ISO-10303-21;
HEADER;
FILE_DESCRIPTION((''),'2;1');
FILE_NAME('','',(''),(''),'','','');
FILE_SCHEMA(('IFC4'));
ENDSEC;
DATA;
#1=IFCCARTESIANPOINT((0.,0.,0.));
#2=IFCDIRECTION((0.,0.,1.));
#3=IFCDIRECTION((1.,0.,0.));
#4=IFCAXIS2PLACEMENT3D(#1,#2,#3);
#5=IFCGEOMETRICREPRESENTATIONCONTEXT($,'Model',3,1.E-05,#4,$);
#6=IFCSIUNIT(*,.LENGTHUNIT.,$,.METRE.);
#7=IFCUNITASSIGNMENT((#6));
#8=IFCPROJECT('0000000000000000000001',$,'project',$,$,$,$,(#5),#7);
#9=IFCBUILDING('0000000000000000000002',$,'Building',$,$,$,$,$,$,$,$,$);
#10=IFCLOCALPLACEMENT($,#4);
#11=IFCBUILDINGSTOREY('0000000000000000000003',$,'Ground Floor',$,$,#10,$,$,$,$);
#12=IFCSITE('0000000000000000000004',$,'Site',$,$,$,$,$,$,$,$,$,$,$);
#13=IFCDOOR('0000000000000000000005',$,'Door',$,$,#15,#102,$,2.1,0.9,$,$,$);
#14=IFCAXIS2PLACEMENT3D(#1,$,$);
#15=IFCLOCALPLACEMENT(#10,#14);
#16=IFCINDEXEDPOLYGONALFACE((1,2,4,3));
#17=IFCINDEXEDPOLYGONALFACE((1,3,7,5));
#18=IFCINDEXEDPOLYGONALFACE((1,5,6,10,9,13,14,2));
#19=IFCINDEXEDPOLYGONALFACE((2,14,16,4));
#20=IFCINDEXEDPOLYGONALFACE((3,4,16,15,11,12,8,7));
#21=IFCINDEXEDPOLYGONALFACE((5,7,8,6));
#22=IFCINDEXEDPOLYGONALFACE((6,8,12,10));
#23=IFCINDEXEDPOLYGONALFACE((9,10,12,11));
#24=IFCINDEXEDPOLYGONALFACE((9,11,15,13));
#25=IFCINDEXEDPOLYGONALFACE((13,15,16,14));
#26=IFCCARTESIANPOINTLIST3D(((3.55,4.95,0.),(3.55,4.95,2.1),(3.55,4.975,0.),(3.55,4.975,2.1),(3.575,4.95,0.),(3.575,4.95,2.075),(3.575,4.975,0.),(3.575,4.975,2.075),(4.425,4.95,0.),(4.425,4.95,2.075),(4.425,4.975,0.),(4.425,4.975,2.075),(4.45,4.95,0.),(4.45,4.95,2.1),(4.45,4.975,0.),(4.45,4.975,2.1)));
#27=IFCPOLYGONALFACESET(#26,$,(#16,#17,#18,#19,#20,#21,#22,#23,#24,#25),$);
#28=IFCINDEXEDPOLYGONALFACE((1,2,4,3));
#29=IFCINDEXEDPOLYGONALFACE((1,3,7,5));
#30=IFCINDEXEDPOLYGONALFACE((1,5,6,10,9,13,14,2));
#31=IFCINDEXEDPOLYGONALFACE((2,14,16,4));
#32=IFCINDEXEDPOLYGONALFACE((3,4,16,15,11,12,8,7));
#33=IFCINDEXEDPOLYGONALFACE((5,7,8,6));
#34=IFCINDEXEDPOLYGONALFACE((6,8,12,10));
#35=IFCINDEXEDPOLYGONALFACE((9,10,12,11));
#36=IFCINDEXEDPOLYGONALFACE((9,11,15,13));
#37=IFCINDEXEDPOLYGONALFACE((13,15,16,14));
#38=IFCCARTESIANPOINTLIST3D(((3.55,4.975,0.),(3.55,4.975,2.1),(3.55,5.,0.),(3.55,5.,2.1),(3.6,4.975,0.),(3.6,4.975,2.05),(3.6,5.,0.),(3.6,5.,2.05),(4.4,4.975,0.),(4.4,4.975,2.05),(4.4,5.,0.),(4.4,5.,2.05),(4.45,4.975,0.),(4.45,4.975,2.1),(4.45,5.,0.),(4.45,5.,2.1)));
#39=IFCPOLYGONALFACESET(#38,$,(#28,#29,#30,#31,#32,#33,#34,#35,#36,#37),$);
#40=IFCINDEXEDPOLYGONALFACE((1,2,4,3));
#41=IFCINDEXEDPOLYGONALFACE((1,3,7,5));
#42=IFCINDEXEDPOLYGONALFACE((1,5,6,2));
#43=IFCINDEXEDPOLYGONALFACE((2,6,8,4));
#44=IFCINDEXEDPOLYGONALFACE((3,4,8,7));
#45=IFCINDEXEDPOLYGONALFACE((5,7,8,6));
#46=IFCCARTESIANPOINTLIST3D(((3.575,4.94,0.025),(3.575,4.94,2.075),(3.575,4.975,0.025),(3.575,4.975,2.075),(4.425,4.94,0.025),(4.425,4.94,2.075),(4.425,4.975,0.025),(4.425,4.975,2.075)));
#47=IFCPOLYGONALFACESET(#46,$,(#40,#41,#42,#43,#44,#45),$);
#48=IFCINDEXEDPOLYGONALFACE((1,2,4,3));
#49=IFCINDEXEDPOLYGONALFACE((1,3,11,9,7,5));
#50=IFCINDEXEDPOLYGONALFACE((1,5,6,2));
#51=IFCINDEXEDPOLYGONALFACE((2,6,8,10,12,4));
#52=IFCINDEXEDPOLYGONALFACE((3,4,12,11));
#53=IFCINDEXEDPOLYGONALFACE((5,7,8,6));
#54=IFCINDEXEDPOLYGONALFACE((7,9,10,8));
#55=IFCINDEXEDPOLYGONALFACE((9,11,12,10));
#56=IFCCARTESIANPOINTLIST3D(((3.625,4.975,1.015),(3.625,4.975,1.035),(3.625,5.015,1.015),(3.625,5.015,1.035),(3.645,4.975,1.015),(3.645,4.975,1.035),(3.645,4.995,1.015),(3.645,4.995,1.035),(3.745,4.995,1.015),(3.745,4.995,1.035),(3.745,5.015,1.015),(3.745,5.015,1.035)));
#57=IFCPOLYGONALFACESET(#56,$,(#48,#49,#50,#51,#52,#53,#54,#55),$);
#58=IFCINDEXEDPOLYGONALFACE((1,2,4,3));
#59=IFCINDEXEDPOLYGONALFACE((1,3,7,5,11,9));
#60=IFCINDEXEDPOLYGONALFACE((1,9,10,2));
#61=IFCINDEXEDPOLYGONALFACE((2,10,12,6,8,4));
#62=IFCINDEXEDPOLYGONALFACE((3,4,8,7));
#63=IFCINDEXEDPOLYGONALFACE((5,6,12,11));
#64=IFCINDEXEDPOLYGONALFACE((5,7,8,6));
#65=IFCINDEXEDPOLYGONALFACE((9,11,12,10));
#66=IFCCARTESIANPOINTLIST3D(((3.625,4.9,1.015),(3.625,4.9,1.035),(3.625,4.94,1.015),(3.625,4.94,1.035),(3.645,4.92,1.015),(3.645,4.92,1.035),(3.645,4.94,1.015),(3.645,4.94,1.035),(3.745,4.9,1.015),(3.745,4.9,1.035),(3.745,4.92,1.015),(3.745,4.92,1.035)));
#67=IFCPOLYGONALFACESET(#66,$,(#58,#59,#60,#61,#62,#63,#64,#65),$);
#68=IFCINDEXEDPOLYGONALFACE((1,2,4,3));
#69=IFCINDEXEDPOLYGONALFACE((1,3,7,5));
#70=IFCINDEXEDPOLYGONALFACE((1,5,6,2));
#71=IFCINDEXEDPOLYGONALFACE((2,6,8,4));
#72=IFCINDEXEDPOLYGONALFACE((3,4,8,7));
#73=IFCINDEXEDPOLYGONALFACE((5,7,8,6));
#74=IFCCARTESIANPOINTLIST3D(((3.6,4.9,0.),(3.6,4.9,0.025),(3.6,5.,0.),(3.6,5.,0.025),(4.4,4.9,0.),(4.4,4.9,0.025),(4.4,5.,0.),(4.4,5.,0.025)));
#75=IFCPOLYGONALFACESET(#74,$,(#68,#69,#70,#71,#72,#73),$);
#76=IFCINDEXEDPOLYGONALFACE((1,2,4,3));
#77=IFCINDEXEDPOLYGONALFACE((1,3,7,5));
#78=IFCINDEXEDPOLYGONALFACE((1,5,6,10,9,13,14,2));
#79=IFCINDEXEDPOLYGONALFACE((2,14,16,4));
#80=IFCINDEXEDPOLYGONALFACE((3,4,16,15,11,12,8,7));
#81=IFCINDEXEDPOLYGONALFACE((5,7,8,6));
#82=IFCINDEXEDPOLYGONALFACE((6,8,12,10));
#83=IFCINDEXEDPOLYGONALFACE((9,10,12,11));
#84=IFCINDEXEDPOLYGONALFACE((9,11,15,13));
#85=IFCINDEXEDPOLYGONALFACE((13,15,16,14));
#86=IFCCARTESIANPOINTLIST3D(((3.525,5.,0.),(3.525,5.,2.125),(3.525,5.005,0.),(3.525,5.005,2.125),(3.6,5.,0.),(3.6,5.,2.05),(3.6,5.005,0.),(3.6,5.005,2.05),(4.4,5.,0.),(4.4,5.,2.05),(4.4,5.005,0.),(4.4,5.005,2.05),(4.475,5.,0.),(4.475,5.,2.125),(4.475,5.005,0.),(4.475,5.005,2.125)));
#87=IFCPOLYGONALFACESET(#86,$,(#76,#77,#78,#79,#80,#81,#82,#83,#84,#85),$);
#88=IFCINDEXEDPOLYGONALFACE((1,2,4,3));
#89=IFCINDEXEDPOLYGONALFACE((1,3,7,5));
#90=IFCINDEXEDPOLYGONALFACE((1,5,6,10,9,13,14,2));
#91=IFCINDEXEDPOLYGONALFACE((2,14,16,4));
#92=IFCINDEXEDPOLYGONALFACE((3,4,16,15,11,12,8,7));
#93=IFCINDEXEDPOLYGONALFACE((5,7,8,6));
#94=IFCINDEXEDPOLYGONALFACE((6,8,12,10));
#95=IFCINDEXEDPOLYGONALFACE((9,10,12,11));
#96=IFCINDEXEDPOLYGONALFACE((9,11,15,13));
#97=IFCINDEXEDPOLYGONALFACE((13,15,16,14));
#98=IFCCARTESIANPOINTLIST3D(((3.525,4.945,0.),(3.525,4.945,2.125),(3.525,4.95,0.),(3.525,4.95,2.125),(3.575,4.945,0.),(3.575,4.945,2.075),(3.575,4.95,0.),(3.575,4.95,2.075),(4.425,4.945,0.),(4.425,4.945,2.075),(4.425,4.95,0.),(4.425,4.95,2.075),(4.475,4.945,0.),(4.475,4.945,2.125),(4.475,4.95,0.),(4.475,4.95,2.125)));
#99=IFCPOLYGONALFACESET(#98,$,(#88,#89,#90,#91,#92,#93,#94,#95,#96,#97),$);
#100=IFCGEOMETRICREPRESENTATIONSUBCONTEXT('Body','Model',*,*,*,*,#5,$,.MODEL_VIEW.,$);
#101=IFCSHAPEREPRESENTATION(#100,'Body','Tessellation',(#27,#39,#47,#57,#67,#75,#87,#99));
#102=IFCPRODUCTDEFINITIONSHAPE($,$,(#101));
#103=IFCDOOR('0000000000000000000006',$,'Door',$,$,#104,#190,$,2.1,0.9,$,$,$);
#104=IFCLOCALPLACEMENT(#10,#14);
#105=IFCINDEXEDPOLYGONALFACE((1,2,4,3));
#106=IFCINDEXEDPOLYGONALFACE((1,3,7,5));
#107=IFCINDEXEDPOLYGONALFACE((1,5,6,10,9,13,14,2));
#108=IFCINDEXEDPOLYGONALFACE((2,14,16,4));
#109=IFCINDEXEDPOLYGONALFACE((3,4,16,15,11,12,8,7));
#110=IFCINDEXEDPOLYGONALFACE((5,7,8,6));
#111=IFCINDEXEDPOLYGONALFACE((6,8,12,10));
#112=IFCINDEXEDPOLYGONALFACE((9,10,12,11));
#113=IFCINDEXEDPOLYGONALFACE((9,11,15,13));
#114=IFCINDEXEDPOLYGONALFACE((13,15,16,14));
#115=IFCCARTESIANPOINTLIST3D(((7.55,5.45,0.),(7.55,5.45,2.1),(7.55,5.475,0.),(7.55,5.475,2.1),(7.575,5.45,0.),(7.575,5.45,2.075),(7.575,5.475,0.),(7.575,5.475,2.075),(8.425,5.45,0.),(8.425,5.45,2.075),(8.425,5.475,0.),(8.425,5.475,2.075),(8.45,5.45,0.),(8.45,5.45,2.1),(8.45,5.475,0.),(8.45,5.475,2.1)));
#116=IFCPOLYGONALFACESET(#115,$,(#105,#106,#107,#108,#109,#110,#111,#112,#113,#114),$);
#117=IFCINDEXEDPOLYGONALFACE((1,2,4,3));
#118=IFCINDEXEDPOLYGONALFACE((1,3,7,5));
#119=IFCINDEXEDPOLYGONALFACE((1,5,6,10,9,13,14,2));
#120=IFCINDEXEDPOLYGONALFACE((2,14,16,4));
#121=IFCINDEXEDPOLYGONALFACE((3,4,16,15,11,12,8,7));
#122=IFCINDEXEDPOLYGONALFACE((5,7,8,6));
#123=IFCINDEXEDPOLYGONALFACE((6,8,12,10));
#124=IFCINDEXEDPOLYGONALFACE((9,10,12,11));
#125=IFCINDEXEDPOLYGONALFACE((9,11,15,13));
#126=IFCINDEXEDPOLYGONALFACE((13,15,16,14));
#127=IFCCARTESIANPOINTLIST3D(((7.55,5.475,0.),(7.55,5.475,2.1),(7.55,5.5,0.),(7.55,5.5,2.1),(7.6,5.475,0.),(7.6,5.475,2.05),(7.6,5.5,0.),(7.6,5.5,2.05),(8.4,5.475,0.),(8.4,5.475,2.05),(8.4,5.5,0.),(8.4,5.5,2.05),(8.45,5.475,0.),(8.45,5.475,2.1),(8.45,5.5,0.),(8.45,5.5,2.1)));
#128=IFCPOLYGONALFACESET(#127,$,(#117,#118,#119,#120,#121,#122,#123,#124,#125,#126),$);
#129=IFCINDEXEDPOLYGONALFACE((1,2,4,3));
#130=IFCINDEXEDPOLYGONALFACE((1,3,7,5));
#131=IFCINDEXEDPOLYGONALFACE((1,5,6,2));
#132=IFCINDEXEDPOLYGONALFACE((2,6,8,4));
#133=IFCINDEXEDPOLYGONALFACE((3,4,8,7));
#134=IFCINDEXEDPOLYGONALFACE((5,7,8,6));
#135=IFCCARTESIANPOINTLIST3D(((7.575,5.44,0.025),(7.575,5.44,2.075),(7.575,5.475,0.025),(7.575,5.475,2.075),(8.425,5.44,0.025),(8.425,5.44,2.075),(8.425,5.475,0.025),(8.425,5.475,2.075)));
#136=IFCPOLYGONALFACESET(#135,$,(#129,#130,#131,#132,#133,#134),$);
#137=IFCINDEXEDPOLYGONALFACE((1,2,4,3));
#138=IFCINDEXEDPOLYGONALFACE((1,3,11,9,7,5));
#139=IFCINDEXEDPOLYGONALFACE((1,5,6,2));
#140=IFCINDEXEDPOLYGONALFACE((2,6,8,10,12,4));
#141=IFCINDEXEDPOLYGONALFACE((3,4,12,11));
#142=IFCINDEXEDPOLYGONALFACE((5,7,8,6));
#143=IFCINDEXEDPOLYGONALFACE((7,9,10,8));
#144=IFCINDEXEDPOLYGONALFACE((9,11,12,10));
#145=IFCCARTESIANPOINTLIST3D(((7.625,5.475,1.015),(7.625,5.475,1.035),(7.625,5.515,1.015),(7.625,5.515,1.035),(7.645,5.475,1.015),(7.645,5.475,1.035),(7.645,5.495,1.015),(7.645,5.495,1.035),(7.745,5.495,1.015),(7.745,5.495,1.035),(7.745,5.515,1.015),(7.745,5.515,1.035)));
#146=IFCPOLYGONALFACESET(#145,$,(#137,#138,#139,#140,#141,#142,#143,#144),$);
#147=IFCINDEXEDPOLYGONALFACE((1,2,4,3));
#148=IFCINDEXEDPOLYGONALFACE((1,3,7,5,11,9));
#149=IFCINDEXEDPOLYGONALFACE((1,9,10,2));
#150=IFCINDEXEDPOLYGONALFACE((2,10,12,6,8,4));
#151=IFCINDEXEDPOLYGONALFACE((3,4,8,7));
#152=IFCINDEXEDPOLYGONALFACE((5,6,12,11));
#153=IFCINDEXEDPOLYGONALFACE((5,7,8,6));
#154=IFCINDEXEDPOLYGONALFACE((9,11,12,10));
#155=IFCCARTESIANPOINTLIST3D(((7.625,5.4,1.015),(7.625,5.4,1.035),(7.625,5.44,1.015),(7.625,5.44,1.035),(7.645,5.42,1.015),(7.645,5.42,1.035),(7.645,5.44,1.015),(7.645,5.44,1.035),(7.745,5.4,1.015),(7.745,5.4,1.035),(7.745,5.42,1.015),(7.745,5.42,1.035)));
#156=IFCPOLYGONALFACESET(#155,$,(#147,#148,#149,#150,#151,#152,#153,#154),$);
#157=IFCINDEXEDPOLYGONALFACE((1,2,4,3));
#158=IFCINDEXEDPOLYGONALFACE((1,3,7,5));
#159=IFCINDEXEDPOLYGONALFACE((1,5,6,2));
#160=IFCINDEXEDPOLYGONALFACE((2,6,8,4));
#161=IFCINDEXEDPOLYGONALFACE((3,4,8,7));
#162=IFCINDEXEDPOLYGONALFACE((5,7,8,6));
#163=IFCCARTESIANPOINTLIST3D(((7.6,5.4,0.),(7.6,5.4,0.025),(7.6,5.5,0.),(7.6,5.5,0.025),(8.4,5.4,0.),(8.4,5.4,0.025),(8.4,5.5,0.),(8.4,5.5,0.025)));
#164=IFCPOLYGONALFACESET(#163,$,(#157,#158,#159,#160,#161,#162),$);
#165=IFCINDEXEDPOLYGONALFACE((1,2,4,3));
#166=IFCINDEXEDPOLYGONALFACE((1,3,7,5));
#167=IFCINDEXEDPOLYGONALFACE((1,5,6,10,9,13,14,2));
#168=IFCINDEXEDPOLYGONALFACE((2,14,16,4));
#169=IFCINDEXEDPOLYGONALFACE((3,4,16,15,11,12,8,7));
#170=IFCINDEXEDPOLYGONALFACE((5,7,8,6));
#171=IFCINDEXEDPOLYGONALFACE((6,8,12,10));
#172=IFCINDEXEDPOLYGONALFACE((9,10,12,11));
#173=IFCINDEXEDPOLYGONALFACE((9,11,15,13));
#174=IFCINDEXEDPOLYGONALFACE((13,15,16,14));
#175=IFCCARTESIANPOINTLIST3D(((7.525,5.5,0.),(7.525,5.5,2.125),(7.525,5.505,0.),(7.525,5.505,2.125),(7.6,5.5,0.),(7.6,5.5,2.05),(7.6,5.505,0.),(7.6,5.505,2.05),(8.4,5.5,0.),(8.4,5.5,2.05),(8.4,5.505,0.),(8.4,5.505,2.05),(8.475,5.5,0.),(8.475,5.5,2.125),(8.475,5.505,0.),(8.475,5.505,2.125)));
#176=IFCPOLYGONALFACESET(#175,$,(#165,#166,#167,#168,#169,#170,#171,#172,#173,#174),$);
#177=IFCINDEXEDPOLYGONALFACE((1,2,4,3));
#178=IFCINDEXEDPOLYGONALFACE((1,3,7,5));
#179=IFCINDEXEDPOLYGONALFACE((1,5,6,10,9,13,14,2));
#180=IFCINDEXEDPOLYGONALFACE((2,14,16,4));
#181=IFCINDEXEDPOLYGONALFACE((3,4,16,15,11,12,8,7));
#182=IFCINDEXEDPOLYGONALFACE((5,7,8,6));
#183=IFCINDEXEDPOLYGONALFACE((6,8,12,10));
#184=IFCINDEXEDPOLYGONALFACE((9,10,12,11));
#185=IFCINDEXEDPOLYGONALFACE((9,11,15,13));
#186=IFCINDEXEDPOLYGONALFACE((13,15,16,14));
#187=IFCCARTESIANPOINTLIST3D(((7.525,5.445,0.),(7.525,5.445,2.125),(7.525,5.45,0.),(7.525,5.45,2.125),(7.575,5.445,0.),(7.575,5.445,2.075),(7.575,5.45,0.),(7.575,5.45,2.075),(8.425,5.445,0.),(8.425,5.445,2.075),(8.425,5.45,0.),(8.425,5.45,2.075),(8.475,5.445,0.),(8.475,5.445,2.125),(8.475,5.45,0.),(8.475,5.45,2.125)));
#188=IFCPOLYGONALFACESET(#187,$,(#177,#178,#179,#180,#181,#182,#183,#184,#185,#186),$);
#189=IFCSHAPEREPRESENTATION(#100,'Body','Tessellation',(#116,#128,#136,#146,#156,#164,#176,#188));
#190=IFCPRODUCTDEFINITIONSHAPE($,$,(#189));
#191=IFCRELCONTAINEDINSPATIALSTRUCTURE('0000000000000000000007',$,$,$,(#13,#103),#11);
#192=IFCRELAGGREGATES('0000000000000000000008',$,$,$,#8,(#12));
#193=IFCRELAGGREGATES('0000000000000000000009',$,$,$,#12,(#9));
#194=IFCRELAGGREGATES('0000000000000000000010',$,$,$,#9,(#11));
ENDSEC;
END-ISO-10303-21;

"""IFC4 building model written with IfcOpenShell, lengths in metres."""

from ifc_helpers import new_model, si_unit, frame, origin_with_axes, place, context, subcontext, project, spatial, line, indexed_curve, outline, extrude, element, save


model = new_model("IFC4")

# Units and contexts
model_context = context("Model", 3, precision=1e-05, world=origin_with_axes())
body_context = subcontext(model_context, "Body", "Model", "MODEL_VIEW")
ifc_project = project(units=[si_unit("LENGTHUNIT", "METRE")], contexts=[model_context])

# Site, building, storey
site = spatial("IfcSite", under=ifc_project, Name="Site")
building = spatial("IfcBuilding", under=site, Name="Building")
storey_placement = place(None, origin_with_axes())
storey = spatial("IfcBuildingStorey", under=building, at=storey_placement, Name="Ground Floor")

# Doors
door_1_placement = place(storey_placement, frame((4.45, 5.0, 0.0), z_axis=(0.0, 0.0, 1.0), x_axis=(-1.0, 0.0, 0.0)))
element("IfcDoor", 1, at=door_1_placement, inside=storey, Name="Door", OverallHeight=2.1, OverallWidth=0.9, context=body_context, shape_type="SweptSolid", body=[
    extrude(outline(indexed_curve([(0.0, 0.0), (0.0, 2.1), (0.9, 2.1), (0.9, 0.0), (0.875, 0.0), (0.875, 2.075), (0.025, 2.075), (0.025, 0.0)], segments=[line(1, 2, 3, 4, 5, 6, 7, 8, 1)])), frame((0.0, 0.025, 0.0), z_axis=(0.0, -1.0, 0.0), x_axis=(1.0, 0.0, 0.0)), (0.0, 0.0, -1.0), 0.025),
    extrude(outline(indexed_curve([(0.0, 0.0), (0.0, 2.1), (0.9, 2.1), (0.9, 0.0), (0.85, 0.0), (0.85, 2.05), (0.05, 2.05), (0.05, 0.0)], segments=[line(1, 2, 3, 4, 5, 6, 7, 8, 1)])), frame((0.0, 0.0, 0.0), z_axis=(0.0, -1.0, 0.0), x_axis=(1.0, 0.0, 0.0)), (0.0, 0.0, -1.0), 0.025),
    extrude(outline(indexed_curve([(0.0, 0.0), (0.85, 0.0), (0.85, 0.035), (0.0, 0.035)], segments=[line(1, 2, 3, 4, 1)])), frame((0.025, 0.025, 0.025), z_axis=(0.0, 0.0, 1.0), x_axis=(1.0, 0.0, 0.0)), (0.0, 0.0, 1.0), 2.05),
    extrude(outline(indexed_curve([(0.0, 0.0), (0.0, -0.04), (-0.12, -0.04), (-0.12, -0.02), (-0.02, -0.02), (-0.02, 0.0)], segments=[line(1, 2, 3, 4, 5, 6, 1)])), frame((0.825, 0.025, 1.015), z_axis=(0.0, 0.0, 1.0), x_axis=(1.0, 0.0, 0.0)), (0.0, 0.0, 1.0), 0.02),
    extrude(outline(indexed_curve([(0.0, 0.0), (0.0, 0.04), (-0.12, 0.04), (-0.12, 0.02), (-0.02, 0.02), (-0.02, 0.0)], segments=[line(1, 2, 3, 4, 5, 6, 1)])), frame((0.825, 0.06, 1.015), z_axis=(0.0, 0.0, 1.0), x_axis=(1.0, 0.0, 0.0)), (0.0, 0.0, 1.0), 0.02),
    extrude(outline(indexed_curve([(0.0, 0.0), (0.8, 0.0), (0.8, 0.1), (0.0, 0.1)], segments=[line(1, 2, 3, 4, 1)])), frame((0.05, 0.0, 0.0), z_axis=(0.0, 0.0, 1.0), x_axis=(1.0, 0.0, 0.0)), (0.0, 0.0, 1.0), 0.025),
    extrude(outline(indexed_curve([(0.0, 0.0), (0.0, 2.125), (0.95, 2.125), (0.95, 0.0), (0.875, 0.0), (0.875, 2.05), (0.075, 2.05), (0.075, 0.0)], segments=[line(1, 2, 3, 4, 5, 6, 7, 8, 1)])), frame((-0.025, -0.005, 0.0), z_axis=(0.0, -1.0, 0.0), x_axis=(1.0, 0.0, 0.0)), (0.0, 0.0, -1.0), 0.005),
    extrude(outline(indexed_curve([(0.0, 0.0), (0.0, 2.125), (0.95, 2.125), (0.95, 0.0), (0.9, 0.0), (0.9, 2.075), (0.05, 2.075), (0.05, 0.0)], segments=[line(1, 2, 3, 4, 5, 6, 7, 8, 1)])), frame((-0.025, 0.05, 0.0), z_axis=(0.0, -1.0, 0.0), x_axis=(1.0, 0.0, 0.0)), (0.0, 0.0, -1.0), 0.005),
])
door_2_placement = place(storey_placement, frame((8.45, 5.5, 0.0), z_axis=(0.0, 0.0, 1.0), x_axis=(-1.0, 0.0, 0.0)))
element("IfcDoor", 2, at=door_2_placement, inside=storey, Name="Door", OverallHeight=2.1, OverallWidth=0.9, context=body_context, shape_type="SweptSolid", body=[
    extrude(outline(indexed_curve([(0.0, 0.0), (0.0, 2.1), (0.9, 2.1), (0.9, 0.0), (0.875, 0.0), (0.875, 2.075), (0.025, 2.075), (0.025, 0.0)], segments=[line(1, 2, 3, 4, 5, 6, 7, 8, 1)])), frame((0.0, 0.025, 0.0), z_axis=(0.0, -1.0, 0.0), x_axis=(1.0, 0.0, 0.0)), (0.0, 0.0, -1.0), 0.025),
    extrude(outline(indexed_curve([(0.0, 0.0), (0.0, 2.1), (0.9, 2.1), (0.9, 0.0), (0.85, 0.0), (0.85, 2.05), (0.05, 2.05), (0.05, 0.0)], segments=[line(1, 2, 3, 4, 5, 6, 7, 8, 1)])), frame((0.0, 0.0, 0.0), z_axis=(0.0, -1.0, 0.0), x_axis=(1.0, 0.0, 0.0)), (0.0, 0.0, -1.0), 0.025),
    extrude(outline(indexed_curve([(0.0, 0.0), (0.85, 0.0), (0.85, 0.035), (0.0, 0.035)], segments=[line(1, 2, 3, 4, 1)])), frame((0.025, 0.025, 0.025), z_axis=(0.0, 0.0, 1.0), x_axis=(1.0, 0.0, 0.0)), (0.0, 0.0, 1.0), 2.05),
    extrude(outline(indexed_curve([(0.0, 0.0), (0.0, -0.04), (-0.12, -0.04), (-0.12, -0.02), (-0.02, -0.02), (-0.02, 0.0)], segments=[line(1, 2, 3, 4, 5, 6, 1)])), frame((0.825, 0.025, 1.015), z_axis=(0.0, 0.0, 1.0), x_axis=(1.0, 0.0, 0.0)), (0.0, 0.0, 1.0), 0.02),
    extrude(outline(indexed_curve([(0.0, 0.0), (0.0, 0.04), (-0.12, 0.04), (-0.12, 0.02), (-0.02, 0.02), (-0.02, 0.0)], segments=[line(1, 2, 3, 4, 5, 6, 1)])), frame((0.825, 0.06, 1.015), z_axis=(0.0, 0.0, 1.0), x_axis=(1.0, 0.0, 0.0)), (0.0, 0.0, 1.0), 0.02),
    extrude(outline(indexed_curve([(0.0, 0.0), (0.8, 0.0), (0.8, 0.1), (0.0, 0.1)], segments=[line(1, 2, 3, 4, 1)])), frame((0.05, 0.0, 0.0), z_axis=(0.0, 0.0, 1.0), x_axis=(1.0, 0.0, 0.0)), (0.0, 0.0, 1.0), 0.025),
    extrude(outline(indexed_curve([(0.0, 0.0), (0.0, 2.125), (0.95, 2.125), (0.95, 0.0), (0.875, 0.0), (0.875, 2.05), (0.075, 2.05), (0.075, 0.0)], segments=[line(1, 2, 3, 4, 5, 6, 7, 8, 1)])), frame((-0.025, -0.005, 0.0), z_axis=(0.0, -1.0, 0.0), x_axis=(1.0, 0.0, 0.0)), (0.0, 0.0, -1.0), 0.005),
    extrude(outline(indexed_curve([(0.0, 0.0), (0.0, 2.125), (0.95, 2.125), (0.95, 0.0), (0.9, 0.0), (0.9, 2.075), (0.05, 2.075), (0.05, 0.0)], segments=[line(1, 2, 3, 4, 5, 6, 7, 8, 1)])), frame((-0.025, 0.05, 0.0), z_axis=(0.0, -1.0, 0.0), x_axis=(1.0, 0.0, 0.0)), (0.0, 0.0, -1.0), 0.005),
])

save(model, "model.ifc")
